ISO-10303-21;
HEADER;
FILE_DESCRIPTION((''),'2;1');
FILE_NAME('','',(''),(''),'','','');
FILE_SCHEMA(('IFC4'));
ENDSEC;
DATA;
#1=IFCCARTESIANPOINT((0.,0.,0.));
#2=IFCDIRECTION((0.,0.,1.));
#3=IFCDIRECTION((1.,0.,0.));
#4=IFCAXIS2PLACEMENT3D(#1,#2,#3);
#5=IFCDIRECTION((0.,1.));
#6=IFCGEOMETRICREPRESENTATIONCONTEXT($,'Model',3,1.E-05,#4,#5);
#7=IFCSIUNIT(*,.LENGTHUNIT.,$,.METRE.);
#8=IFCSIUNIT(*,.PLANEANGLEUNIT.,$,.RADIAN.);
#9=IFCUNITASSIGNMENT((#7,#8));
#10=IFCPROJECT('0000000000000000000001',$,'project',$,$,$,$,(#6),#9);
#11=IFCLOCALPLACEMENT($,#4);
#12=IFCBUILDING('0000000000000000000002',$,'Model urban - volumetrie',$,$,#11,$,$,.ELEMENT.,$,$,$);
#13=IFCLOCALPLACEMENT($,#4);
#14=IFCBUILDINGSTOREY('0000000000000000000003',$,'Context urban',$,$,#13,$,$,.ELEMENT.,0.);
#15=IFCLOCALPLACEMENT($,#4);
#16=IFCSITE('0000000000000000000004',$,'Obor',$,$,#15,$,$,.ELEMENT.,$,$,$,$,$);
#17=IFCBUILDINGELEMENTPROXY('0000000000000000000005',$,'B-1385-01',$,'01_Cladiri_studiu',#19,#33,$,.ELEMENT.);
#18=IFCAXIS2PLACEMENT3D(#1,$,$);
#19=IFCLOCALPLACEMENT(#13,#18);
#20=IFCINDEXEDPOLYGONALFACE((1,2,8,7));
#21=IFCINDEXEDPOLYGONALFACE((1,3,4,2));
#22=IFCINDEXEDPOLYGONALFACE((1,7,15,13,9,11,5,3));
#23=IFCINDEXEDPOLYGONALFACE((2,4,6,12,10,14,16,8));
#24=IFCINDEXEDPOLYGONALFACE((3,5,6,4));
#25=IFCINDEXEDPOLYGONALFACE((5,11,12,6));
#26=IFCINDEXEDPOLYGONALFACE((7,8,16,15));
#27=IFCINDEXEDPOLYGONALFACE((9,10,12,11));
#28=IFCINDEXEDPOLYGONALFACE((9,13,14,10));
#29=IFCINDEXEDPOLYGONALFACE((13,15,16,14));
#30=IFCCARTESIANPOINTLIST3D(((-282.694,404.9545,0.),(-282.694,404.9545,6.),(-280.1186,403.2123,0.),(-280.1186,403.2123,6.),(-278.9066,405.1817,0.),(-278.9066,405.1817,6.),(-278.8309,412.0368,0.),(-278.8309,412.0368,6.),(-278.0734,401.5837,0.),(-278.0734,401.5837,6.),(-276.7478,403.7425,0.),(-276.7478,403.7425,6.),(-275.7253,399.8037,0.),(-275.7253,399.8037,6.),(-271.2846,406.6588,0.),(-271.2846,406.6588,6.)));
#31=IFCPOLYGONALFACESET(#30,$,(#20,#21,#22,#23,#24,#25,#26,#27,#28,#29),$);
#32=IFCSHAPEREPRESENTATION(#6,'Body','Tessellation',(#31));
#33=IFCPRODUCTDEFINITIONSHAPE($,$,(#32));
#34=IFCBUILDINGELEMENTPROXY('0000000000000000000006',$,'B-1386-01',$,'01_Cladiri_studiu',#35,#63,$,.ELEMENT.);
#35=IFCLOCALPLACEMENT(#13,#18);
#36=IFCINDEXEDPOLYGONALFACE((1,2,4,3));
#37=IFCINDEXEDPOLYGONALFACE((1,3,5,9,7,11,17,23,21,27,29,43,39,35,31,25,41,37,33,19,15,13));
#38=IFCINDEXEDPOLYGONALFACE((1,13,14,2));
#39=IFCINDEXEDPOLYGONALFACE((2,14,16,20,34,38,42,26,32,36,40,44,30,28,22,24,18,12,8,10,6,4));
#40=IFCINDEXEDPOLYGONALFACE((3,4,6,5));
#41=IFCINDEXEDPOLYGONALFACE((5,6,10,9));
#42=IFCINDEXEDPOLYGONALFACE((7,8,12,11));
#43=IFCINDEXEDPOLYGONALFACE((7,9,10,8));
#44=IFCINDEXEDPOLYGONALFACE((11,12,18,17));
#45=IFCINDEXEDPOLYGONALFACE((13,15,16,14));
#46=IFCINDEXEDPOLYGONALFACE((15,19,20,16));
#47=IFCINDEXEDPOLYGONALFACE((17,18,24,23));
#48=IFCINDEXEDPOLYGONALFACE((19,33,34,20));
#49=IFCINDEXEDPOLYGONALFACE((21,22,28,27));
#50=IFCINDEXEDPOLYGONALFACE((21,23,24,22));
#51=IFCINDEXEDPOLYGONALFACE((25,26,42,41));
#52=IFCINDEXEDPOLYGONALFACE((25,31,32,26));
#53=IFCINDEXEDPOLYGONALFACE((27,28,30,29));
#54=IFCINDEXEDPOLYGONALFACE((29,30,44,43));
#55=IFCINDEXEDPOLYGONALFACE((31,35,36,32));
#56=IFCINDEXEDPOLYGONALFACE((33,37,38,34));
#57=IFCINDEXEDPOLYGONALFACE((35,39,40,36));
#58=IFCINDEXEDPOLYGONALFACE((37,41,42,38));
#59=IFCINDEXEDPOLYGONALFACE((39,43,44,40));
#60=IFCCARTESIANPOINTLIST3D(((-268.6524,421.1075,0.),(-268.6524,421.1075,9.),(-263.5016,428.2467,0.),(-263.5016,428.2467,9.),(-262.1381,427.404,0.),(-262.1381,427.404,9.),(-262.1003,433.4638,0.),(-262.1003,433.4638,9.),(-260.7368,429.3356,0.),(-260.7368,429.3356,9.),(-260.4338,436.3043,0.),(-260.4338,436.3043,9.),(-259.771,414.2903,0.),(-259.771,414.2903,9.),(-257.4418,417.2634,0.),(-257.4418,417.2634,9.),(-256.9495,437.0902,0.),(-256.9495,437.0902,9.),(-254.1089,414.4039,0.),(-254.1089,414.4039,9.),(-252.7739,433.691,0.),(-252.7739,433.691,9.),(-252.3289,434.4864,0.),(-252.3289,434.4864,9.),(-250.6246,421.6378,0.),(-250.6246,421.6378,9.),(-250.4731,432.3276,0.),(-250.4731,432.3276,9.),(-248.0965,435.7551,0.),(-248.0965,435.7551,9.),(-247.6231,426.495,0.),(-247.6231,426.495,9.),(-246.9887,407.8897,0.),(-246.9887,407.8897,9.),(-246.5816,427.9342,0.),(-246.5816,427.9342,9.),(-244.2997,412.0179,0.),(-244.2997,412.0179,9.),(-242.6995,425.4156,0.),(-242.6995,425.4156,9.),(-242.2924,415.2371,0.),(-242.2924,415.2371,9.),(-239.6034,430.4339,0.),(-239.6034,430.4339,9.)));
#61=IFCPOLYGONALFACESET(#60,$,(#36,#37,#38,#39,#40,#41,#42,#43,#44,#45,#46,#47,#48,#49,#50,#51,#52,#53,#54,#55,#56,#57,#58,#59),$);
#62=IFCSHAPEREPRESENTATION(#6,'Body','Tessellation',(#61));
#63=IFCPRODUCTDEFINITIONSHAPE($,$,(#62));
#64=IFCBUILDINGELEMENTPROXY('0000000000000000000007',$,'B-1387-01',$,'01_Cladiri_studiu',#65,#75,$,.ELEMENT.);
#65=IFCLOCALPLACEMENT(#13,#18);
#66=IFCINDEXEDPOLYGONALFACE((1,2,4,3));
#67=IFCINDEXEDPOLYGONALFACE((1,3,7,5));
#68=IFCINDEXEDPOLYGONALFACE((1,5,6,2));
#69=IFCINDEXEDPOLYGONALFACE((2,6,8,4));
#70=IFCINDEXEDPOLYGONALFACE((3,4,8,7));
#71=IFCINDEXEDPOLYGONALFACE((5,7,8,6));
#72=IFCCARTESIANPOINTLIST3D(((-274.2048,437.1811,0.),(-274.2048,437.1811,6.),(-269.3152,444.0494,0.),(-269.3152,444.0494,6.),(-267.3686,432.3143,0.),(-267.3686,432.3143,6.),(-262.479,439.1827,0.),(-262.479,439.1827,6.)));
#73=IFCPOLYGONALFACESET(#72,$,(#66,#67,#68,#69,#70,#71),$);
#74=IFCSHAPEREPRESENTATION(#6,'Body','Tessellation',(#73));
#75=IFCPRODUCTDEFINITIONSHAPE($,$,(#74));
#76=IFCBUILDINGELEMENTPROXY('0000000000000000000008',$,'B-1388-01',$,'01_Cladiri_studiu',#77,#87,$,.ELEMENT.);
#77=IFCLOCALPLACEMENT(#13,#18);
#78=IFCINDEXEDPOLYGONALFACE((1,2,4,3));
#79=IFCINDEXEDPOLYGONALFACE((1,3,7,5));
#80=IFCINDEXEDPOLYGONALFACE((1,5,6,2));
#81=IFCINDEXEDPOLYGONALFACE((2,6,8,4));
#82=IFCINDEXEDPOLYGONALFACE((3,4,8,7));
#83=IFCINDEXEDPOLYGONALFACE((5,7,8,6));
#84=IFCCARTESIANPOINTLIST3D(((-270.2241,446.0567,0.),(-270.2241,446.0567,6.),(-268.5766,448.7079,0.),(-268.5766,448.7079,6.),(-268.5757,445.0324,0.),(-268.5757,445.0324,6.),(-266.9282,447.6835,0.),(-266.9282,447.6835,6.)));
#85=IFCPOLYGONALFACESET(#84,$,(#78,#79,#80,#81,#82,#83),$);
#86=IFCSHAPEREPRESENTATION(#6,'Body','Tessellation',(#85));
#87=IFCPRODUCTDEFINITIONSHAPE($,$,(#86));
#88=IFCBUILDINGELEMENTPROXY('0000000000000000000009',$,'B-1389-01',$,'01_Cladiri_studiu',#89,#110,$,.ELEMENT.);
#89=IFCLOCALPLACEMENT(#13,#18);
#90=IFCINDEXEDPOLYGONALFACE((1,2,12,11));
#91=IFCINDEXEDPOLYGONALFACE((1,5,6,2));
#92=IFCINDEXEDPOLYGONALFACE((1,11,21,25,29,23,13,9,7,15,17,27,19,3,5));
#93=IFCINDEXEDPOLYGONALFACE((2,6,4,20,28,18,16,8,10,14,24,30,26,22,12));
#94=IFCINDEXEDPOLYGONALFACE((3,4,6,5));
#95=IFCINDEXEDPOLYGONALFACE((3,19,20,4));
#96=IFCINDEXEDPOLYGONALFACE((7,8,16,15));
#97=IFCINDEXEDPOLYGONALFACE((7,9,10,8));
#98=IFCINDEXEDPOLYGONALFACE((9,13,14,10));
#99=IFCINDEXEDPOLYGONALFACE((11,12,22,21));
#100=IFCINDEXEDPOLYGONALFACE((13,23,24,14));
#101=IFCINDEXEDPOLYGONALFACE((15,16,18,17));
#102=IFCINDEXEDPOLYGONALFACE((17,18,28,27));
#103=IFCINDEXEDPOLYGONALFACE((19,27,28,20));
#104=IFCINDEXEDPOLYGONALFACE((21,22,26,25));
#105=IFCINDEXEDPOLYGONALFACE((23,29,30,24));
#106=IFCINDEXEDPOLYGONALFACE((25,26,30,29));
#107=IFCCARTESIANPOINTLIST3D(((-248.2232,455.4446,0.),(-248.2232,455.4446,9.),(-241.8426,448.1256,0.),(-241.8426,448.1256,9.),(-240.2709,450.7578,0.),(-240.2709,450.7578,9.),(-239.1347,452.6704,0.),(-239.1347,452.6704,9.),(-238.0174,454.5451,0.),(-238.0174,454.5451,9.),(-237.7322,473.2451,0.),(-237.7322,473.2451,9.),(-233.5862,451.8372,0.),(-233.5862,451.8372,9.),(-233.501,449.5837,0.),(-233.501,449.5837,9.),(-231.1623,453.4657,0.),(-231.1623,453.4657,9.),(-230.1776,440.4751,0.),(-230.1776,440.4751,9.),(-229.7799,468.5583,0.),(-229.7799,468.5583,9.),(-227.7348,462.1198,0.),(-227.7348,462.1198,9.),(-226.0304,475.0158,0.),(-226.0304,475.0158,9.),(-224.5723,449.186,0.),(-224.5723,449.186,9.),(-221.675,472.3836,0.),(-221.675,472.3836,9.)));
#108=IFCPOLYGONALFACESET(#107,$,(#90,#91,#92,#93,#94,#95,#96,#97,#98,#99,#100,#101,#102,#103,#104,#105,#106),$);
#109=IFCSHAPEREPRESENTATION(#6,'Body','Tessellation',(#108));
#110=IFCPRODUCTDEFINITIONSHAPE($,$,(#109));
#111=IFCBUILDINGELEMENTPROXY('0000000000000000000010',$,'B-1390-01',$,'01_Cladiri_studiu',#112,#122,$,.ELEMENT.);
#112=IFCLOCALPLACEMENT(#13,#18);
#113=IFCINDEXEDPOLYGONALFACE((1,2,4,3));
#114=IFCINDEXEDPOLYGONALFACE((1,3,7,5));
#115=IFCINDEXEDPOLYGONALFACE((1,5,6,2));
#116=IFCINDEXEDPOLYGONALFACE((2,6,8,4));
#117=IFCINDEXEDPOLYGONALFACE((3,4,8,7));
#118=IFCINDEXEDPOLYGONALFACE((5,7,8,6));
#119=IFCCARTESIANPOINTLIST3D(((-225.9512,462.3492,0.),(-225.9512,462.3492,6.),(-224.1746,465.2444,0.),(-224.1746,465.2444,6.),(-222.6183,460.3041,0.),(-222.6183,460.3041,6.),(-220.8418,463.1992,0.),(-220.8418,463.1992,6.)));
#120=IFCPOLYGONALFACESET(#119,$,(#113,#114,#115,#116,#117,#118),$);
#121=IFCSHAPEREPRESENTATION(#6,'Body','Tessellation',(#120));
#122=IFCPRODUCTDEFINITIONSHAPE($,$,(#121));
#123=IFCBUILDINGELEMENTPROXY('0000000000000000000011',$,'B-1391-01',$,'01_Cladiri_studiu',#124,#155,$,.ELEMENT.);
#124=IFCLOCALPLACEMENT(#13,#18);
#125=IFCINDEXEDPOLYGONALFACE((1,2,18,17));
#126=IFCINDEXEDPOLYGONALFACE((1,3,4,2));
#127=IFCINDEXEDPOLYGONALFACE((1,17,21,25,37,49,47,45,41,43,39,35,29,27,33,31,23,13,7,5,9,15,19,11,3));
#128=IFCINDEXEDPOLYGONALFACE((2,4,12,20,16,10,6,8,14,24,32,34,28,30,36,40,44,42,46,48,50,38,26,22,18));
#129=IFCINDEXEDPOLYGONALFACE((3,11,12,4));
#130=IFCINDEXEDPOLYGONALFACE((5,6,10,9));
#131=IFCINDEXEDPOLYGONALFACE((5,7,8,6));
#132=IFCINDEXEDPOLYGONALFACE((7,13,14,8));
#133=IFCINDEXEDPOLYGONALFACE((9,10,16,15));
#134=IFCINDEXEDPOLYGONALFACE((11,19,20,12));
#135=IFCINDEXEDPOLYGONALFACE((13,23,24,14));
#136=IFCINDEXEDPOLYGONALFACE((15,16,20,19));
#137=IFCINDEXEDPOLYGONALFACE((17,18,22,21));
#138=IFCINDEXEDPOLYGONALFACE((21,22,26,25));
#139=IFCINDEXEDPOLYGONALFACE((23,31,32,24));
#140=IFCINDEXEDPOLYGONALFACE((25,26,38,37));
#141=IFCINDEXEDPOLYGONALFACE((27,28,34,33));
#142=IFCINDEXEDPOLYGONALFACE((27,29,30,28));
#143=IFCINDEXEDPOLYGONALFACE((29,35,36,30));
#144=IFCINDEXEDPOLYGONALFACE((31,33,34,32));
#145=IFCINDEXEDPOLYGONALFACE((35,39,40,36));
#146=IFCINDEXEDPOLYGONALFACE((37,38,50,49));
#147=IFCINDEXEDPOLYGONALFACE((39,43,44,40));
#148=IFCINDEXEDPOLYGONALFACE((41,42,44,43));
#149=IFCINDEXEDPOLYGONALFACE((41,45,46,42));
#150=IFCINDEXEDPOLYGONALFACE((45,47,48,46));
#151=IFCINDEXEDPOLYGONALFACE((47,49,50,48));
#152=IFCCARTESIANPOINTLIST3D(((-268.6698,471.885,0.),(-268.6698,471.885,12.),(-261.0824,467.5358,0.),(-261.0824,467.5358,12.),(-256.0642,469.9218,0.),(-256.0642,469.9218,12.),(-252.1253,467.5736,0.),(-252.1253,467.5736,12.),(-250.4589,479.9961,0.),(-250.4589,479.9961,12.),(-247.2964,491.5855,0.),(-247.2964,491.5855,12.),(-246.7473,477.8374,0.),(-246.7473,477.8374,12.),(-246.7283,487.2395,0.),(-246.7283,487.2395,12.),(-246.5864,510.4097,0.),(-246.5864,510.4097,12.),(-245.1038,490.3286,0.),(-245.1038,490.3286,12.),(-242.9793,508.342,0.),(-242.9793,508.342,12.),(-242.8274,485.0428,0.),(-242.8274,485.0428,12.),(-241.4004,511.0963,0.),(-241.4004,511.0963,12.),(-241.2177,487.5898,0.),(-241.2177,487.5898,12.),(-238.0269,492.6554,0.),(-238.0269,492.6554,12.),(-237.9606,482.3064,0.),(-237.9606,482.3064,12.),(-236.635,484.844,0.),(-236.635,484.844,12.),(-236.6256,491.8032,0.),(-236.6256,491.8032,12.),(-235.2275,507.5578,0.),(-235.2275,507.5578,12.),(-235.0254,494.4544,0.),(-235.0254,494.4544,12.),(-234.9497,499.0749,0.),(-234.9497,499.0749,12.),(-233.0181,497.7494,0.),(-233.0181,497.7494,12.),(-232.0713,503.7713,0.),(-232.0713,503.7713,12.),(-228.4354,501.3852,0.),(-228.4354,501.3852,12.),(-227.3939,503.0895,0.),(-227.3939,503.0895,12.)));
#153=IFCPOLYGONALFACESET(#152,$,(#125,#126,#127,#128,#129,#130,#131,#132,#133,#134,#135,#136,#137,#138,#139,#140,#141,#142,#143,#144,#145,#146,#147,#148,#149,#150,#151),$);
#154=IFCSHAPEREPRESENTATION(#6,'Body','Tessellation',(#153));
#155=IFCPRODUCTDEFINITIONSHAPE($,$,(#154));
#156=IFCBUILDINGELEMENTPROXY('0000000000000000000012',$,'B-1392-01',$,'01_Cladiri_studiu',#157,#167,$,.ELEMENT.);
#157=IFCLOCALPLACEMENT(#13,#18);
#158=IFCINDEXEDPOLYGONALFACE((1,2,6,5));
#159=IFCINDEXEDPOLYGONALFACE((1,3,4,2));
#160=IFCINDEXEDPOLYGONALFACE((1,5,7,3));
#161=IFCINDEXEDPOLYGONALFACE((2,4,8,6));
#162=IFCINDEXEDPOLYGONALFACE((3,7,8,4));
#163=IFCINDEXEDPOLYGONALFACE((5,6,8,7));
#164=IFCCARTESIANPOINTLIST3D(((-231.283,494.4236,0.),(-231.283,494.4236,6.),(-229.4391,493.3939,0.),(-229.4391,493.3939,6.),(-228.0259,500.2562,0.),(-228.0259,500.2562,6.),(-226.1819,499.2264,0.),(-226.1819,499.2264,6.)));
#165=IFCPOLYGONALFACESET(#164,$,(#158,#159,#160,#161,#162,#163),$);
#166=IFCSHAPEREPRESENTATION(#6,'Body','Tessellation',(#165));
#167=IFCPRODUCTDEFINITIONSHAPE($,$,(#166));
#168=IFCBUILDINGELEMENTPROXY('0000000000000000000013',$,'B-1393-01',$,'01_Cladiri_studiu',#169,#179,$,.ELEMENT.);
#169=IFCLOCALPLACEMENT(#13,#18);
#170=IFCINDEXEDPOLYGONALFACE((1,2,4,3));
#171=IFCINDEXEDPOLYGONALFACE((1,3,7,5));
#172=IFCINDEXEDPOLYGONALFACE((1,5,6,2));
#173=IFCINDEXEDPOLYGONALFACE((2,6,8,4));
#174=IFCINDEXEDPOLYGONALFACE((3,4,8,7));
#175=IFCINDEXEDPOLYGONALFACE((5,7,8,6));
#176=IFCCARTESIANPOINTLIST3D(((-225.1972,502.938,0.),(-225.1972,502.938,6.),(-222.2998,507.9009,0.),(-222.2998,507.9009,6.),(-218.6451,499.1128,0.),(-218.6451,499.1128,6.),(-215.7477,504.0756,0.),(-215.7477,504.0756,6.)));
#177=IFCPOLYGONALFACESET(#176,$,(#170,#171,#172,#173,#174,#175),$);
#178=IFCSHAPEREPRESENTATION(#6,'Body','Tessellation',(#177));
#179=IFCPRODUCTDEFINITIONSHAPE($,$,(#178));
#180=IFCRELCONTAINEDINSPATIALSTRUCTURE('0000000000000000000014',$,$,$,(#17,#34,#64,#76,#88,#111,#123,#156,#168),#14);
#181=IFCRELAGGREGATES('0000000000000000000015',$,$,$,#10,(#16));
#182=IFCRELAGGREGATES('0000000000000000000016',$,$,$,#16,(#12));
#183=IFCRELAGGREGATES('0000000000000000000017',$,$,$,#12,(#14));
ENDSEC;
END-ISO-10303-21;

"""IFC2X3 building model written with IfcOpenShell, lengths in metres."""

from ifc_helpers import new_model, si_unit, direction, origin_with_axes, place, context, project, spatial, polyline, outline, extrude, element, save


model = new_model("IFC2X3")

# Units and contexts
model_context = context("Model", 3, precision=1e-05, world=origin_with_axes(), true_north=direction((0.0, 1.0)))
ifc_project = project(units=[si_unit("LENGTHUNIT", "METRE"), si_unit("PLANEANGLEUNIT", "RADIAN")], contexts=[model_context])

# Site, building, storey
site_placement = place(None, origin_with_axes())
site = spatial("IfcSite", under=ifc_project, at=site_placement, Name="Obor", CompositionType="ELEMENT")
building_placement = place(None, origin_with_axes())
building = spatial("IfcBuilding", under=site, at=building_placement, Name="Model urban - volumetrie", CompositionType="ELEMENT")
storey_placement = place(None, origin_with_axes())
storey = spatial("IfcBuildingStorey", under=building, at=storey_placement, Name="Context urban", CompositionType="ELEMENT", Elevation=0.0)

# Building element proxies
proxy_1_placement = place(None, origin_with_axes())
element("IfcBuildingElementProxy", 1, at=proxy_1_placement, inside=storey, Name="B-1385-01", ObjectType="01_Cladiri_studiu", CompositionType="ELEMENT", context=model_context, shape_type="SweptSolid", body=[
    extrude(outline(polyline([(-282.694, 404.9545), (-280.1186, 403.2123), (-278.9066, 405.1817), (-276.7478, 403.7425), (-278.0734, 401.5837), (-275.7253, 399.8037), (-271.2846, 406.6588), (-278.8309, 412.0368), (-282.694, 404.9545)])), origin_with_axes(), (0.0, 0.0, 1.0), 6.0),
])
proxy_2_placement = place(None, origin_with_axes())
element("IfcBuildingElementProxy", 2, at=proxy_2_placement, inside=storey, Name="B-1386-01", ObjectType="01_Cladiri_studiu", CompositionType="ELEMENT", context=model_context, shape_type="SweptSolid", body=[
    extrude(outline(polyline([(-262.1003, 433.4638), (-260.7368, 429.3356), (-262.1381, 427.404), (-263.5016, 428.2467), (-268.6524, 421.1075), (-259.771, 414.2903), (-257.4418, 417.2634), (-254.1089, 414.4039), (-246.9887, 407.8897), (-244.2997, 412.0179), (-242.2924, 415.2371), (-250.6246, 421.6378), (-247.6231, 426.495), (-246.5816, 427.9342), (-242.6995, 425.4156), (-239.6034, 430.4339), (-248.0965, 435.7551), (-250.4731, 432.3276), (-252.7739, 433.691), (-252.3289, 434.4864), (-256.9495, 437.0902), (-260.4338, 436.3043), (-262.1003, 433.4638)])), origin_with_axes(), (0.0, 0.0, 1.0), 9.0),
])
proxy_3_placement = place(None, origin_with_axes())
element("IfcBuildingElementProxy", 3, at=proxy_3_placement, inside=storey, Name="B-1387-01", ObjectType="01_Cladiri_studiu", CompositionType="ELEMENT", context=model_context, shape_type="SweptSolid", body=[
    extrude(outline(polyline([(-267.3686, 432.3143), (-262.479, 439.1827), (-269.3152, 444.0494), (-274.2048, 437.1811), (-267.3686, 432.3143)])), origin_with_axes(), (0.0, 0.0, 1.0), 6.0),
])
proxy_4_placement = place(None, origin_with_axes())
element("IfcBuildingElementProxy", 4, at=proxy_4_placement, inside=storey, Name="B-1388-01", ObjectType="01_Cladiri_studiu", CompositionType="ELEMENT", context=model_context, shape_type="SweptSolid", body=[
    extrude(outline(polyline([(-266.9282, 447.6835), (-268.5766, 448.7079), (-270.2241, 446.0567), (-268.5757, 445.0324), (-266.9282, 447.6835)])), origin_with_axes(), (0.0, 0.0, 1.0), 6.0),
])
proxy_5_placement = place(None, origin_with_axes())
element("IfcBuildingElementProxy", 5, at=proxy_5_placement, inside=storey, Name="B-1389-01", ObjectType="01_Cladiri_studiu", CompositionType="ELEMENT", context=model_context, shape_type="SweptSolid", body=[
    extrude(outline(polyline([(-238.0174, 454.5451), (-233.5862, 451.8372), (-227.7348, 462.1198), (-221.675, 472.3836), (-226.0304, 475.0158), (-229.7799, 468.5583), (-237.7322, 473.2451), (-248.2232, 455.4446), (-240.2709, 450.7578), (-241.8426, 448.1256), (-230.1776, 440.4751), (-224.5723, 449.186), (-231.1623, 453.4657), (-233.501, 449.5837), (-239.1347, 452.6704), (-238.0174, 454.5451)]), holes=[polyline([(-232.0523, 464.6952), (-227.7348, 462.1198), (-232.0523, 464.6952), (-234.0407, 461.3119), (-232.0523, 464.6952)])]), origin_with_axes(), (0.0, 0.0, 1.0), 9.0),
])
proxy_6_placement = place(None, origin_with_axes())
element("IfcBuildingElementProxy", 6, at=proxy_6_placement, inside=storey, Name="B-1390-01", ObjectType="01_Cladiri_studiu", CompositionType="ELEMENT", context=model_context, shape_type="SweptSolid", body=[
    extrude(outline(polyline([(-222.6183, 460.3041), (-220.8418, 463.1992), (-224.1746, 465.2444), (-225.9512, 462.3492), (-222.6183, 460.3041)])), origin_with_axes(), (0.0, 0.0, 1.0), 6.0),
])
proxy_7_placement = place(None, origin_with_axes())
element("IfcBuildingElementProxy", 7, at=proxy_7_placement, inside=storey, Name="B-1391-01", ObjectType="01_Cladiri_studiu", CompositionType="ELEMENT", context=model_context, shape_type="SweptSolid", body=[
    extrude(outline(polyline([(-268.6698, 471.885), (-261.0824, 467.5358), (-247.2964, 491.5855), (-245.1038, 490.3286), (-246.7283, 487.2395), (-250.4589, 479.9961), (-256.0642, 469.9218), (-252.1253, 467.5736), (-246.7473, 477.8374), (-242.8274, 485.0428), (-237.9606, 482.3064), (-236.635, 484.844), (-241.2177, 487.5898), (-238.0269, 492.6554), (-236.6256, 491.8032), (-235.0254, 494.4544), (-233.0181, 497.7494), (-234.9497, 499.0749), (-232.0713, 503.7713), (-228.4354, 501.3852), (-227.3939, 503.0895), (-235.2275, 507.5578), (-241.4004, 511.0963), (-242.9793, 508.342), (-246.5864, 510.4097), (-268.6698, 471.885)])), origin_with_axes(), (0.0, 0.0, 1.0), 12.0),
])
proxy_8_placement = place(None, origin_with_axes())
element("IfcBuildingElementProxy", 8, at=proxy_8_placement, inside=storey, Name="B-1392-01", ObjectType="01_Cladiri_studiu", CompositionType="ELEMENT", context=model_context, shape_type="SweptSolid", body=[
    extrude(outline(polyline([(-228.0259, 500.2562), (-231.283, 494.4236), (-229.4391, 493.3939), (-226.1819, 499.2264), (-228.0259, 500.2562)])), origin_with_axes(), (0.0, 0.0, 1.0), 6.0),
])
proxy_9_placement = place(None, origin_with_axes())
element("IfcBuildingElementProxy", 9, at=proxy_9_placement, inside=storey, Name="B-1393-01", ObjectType="01_Cladiri_studiu", CompositionType="ELEMENT", context=model_context, shape_type="SweptSolid", body=[
    extrude(outline(polyline([(-218.6451, 499.1128), (-215.7477, 504.0756), (-222.2998, 507.9009), (-225.1972, 502.938), (-218.6451, 499.1128)])), origin_with_axes(), (0.0, 0.0, 1.0), 6.0),
])

save(model, "model.ifc")
